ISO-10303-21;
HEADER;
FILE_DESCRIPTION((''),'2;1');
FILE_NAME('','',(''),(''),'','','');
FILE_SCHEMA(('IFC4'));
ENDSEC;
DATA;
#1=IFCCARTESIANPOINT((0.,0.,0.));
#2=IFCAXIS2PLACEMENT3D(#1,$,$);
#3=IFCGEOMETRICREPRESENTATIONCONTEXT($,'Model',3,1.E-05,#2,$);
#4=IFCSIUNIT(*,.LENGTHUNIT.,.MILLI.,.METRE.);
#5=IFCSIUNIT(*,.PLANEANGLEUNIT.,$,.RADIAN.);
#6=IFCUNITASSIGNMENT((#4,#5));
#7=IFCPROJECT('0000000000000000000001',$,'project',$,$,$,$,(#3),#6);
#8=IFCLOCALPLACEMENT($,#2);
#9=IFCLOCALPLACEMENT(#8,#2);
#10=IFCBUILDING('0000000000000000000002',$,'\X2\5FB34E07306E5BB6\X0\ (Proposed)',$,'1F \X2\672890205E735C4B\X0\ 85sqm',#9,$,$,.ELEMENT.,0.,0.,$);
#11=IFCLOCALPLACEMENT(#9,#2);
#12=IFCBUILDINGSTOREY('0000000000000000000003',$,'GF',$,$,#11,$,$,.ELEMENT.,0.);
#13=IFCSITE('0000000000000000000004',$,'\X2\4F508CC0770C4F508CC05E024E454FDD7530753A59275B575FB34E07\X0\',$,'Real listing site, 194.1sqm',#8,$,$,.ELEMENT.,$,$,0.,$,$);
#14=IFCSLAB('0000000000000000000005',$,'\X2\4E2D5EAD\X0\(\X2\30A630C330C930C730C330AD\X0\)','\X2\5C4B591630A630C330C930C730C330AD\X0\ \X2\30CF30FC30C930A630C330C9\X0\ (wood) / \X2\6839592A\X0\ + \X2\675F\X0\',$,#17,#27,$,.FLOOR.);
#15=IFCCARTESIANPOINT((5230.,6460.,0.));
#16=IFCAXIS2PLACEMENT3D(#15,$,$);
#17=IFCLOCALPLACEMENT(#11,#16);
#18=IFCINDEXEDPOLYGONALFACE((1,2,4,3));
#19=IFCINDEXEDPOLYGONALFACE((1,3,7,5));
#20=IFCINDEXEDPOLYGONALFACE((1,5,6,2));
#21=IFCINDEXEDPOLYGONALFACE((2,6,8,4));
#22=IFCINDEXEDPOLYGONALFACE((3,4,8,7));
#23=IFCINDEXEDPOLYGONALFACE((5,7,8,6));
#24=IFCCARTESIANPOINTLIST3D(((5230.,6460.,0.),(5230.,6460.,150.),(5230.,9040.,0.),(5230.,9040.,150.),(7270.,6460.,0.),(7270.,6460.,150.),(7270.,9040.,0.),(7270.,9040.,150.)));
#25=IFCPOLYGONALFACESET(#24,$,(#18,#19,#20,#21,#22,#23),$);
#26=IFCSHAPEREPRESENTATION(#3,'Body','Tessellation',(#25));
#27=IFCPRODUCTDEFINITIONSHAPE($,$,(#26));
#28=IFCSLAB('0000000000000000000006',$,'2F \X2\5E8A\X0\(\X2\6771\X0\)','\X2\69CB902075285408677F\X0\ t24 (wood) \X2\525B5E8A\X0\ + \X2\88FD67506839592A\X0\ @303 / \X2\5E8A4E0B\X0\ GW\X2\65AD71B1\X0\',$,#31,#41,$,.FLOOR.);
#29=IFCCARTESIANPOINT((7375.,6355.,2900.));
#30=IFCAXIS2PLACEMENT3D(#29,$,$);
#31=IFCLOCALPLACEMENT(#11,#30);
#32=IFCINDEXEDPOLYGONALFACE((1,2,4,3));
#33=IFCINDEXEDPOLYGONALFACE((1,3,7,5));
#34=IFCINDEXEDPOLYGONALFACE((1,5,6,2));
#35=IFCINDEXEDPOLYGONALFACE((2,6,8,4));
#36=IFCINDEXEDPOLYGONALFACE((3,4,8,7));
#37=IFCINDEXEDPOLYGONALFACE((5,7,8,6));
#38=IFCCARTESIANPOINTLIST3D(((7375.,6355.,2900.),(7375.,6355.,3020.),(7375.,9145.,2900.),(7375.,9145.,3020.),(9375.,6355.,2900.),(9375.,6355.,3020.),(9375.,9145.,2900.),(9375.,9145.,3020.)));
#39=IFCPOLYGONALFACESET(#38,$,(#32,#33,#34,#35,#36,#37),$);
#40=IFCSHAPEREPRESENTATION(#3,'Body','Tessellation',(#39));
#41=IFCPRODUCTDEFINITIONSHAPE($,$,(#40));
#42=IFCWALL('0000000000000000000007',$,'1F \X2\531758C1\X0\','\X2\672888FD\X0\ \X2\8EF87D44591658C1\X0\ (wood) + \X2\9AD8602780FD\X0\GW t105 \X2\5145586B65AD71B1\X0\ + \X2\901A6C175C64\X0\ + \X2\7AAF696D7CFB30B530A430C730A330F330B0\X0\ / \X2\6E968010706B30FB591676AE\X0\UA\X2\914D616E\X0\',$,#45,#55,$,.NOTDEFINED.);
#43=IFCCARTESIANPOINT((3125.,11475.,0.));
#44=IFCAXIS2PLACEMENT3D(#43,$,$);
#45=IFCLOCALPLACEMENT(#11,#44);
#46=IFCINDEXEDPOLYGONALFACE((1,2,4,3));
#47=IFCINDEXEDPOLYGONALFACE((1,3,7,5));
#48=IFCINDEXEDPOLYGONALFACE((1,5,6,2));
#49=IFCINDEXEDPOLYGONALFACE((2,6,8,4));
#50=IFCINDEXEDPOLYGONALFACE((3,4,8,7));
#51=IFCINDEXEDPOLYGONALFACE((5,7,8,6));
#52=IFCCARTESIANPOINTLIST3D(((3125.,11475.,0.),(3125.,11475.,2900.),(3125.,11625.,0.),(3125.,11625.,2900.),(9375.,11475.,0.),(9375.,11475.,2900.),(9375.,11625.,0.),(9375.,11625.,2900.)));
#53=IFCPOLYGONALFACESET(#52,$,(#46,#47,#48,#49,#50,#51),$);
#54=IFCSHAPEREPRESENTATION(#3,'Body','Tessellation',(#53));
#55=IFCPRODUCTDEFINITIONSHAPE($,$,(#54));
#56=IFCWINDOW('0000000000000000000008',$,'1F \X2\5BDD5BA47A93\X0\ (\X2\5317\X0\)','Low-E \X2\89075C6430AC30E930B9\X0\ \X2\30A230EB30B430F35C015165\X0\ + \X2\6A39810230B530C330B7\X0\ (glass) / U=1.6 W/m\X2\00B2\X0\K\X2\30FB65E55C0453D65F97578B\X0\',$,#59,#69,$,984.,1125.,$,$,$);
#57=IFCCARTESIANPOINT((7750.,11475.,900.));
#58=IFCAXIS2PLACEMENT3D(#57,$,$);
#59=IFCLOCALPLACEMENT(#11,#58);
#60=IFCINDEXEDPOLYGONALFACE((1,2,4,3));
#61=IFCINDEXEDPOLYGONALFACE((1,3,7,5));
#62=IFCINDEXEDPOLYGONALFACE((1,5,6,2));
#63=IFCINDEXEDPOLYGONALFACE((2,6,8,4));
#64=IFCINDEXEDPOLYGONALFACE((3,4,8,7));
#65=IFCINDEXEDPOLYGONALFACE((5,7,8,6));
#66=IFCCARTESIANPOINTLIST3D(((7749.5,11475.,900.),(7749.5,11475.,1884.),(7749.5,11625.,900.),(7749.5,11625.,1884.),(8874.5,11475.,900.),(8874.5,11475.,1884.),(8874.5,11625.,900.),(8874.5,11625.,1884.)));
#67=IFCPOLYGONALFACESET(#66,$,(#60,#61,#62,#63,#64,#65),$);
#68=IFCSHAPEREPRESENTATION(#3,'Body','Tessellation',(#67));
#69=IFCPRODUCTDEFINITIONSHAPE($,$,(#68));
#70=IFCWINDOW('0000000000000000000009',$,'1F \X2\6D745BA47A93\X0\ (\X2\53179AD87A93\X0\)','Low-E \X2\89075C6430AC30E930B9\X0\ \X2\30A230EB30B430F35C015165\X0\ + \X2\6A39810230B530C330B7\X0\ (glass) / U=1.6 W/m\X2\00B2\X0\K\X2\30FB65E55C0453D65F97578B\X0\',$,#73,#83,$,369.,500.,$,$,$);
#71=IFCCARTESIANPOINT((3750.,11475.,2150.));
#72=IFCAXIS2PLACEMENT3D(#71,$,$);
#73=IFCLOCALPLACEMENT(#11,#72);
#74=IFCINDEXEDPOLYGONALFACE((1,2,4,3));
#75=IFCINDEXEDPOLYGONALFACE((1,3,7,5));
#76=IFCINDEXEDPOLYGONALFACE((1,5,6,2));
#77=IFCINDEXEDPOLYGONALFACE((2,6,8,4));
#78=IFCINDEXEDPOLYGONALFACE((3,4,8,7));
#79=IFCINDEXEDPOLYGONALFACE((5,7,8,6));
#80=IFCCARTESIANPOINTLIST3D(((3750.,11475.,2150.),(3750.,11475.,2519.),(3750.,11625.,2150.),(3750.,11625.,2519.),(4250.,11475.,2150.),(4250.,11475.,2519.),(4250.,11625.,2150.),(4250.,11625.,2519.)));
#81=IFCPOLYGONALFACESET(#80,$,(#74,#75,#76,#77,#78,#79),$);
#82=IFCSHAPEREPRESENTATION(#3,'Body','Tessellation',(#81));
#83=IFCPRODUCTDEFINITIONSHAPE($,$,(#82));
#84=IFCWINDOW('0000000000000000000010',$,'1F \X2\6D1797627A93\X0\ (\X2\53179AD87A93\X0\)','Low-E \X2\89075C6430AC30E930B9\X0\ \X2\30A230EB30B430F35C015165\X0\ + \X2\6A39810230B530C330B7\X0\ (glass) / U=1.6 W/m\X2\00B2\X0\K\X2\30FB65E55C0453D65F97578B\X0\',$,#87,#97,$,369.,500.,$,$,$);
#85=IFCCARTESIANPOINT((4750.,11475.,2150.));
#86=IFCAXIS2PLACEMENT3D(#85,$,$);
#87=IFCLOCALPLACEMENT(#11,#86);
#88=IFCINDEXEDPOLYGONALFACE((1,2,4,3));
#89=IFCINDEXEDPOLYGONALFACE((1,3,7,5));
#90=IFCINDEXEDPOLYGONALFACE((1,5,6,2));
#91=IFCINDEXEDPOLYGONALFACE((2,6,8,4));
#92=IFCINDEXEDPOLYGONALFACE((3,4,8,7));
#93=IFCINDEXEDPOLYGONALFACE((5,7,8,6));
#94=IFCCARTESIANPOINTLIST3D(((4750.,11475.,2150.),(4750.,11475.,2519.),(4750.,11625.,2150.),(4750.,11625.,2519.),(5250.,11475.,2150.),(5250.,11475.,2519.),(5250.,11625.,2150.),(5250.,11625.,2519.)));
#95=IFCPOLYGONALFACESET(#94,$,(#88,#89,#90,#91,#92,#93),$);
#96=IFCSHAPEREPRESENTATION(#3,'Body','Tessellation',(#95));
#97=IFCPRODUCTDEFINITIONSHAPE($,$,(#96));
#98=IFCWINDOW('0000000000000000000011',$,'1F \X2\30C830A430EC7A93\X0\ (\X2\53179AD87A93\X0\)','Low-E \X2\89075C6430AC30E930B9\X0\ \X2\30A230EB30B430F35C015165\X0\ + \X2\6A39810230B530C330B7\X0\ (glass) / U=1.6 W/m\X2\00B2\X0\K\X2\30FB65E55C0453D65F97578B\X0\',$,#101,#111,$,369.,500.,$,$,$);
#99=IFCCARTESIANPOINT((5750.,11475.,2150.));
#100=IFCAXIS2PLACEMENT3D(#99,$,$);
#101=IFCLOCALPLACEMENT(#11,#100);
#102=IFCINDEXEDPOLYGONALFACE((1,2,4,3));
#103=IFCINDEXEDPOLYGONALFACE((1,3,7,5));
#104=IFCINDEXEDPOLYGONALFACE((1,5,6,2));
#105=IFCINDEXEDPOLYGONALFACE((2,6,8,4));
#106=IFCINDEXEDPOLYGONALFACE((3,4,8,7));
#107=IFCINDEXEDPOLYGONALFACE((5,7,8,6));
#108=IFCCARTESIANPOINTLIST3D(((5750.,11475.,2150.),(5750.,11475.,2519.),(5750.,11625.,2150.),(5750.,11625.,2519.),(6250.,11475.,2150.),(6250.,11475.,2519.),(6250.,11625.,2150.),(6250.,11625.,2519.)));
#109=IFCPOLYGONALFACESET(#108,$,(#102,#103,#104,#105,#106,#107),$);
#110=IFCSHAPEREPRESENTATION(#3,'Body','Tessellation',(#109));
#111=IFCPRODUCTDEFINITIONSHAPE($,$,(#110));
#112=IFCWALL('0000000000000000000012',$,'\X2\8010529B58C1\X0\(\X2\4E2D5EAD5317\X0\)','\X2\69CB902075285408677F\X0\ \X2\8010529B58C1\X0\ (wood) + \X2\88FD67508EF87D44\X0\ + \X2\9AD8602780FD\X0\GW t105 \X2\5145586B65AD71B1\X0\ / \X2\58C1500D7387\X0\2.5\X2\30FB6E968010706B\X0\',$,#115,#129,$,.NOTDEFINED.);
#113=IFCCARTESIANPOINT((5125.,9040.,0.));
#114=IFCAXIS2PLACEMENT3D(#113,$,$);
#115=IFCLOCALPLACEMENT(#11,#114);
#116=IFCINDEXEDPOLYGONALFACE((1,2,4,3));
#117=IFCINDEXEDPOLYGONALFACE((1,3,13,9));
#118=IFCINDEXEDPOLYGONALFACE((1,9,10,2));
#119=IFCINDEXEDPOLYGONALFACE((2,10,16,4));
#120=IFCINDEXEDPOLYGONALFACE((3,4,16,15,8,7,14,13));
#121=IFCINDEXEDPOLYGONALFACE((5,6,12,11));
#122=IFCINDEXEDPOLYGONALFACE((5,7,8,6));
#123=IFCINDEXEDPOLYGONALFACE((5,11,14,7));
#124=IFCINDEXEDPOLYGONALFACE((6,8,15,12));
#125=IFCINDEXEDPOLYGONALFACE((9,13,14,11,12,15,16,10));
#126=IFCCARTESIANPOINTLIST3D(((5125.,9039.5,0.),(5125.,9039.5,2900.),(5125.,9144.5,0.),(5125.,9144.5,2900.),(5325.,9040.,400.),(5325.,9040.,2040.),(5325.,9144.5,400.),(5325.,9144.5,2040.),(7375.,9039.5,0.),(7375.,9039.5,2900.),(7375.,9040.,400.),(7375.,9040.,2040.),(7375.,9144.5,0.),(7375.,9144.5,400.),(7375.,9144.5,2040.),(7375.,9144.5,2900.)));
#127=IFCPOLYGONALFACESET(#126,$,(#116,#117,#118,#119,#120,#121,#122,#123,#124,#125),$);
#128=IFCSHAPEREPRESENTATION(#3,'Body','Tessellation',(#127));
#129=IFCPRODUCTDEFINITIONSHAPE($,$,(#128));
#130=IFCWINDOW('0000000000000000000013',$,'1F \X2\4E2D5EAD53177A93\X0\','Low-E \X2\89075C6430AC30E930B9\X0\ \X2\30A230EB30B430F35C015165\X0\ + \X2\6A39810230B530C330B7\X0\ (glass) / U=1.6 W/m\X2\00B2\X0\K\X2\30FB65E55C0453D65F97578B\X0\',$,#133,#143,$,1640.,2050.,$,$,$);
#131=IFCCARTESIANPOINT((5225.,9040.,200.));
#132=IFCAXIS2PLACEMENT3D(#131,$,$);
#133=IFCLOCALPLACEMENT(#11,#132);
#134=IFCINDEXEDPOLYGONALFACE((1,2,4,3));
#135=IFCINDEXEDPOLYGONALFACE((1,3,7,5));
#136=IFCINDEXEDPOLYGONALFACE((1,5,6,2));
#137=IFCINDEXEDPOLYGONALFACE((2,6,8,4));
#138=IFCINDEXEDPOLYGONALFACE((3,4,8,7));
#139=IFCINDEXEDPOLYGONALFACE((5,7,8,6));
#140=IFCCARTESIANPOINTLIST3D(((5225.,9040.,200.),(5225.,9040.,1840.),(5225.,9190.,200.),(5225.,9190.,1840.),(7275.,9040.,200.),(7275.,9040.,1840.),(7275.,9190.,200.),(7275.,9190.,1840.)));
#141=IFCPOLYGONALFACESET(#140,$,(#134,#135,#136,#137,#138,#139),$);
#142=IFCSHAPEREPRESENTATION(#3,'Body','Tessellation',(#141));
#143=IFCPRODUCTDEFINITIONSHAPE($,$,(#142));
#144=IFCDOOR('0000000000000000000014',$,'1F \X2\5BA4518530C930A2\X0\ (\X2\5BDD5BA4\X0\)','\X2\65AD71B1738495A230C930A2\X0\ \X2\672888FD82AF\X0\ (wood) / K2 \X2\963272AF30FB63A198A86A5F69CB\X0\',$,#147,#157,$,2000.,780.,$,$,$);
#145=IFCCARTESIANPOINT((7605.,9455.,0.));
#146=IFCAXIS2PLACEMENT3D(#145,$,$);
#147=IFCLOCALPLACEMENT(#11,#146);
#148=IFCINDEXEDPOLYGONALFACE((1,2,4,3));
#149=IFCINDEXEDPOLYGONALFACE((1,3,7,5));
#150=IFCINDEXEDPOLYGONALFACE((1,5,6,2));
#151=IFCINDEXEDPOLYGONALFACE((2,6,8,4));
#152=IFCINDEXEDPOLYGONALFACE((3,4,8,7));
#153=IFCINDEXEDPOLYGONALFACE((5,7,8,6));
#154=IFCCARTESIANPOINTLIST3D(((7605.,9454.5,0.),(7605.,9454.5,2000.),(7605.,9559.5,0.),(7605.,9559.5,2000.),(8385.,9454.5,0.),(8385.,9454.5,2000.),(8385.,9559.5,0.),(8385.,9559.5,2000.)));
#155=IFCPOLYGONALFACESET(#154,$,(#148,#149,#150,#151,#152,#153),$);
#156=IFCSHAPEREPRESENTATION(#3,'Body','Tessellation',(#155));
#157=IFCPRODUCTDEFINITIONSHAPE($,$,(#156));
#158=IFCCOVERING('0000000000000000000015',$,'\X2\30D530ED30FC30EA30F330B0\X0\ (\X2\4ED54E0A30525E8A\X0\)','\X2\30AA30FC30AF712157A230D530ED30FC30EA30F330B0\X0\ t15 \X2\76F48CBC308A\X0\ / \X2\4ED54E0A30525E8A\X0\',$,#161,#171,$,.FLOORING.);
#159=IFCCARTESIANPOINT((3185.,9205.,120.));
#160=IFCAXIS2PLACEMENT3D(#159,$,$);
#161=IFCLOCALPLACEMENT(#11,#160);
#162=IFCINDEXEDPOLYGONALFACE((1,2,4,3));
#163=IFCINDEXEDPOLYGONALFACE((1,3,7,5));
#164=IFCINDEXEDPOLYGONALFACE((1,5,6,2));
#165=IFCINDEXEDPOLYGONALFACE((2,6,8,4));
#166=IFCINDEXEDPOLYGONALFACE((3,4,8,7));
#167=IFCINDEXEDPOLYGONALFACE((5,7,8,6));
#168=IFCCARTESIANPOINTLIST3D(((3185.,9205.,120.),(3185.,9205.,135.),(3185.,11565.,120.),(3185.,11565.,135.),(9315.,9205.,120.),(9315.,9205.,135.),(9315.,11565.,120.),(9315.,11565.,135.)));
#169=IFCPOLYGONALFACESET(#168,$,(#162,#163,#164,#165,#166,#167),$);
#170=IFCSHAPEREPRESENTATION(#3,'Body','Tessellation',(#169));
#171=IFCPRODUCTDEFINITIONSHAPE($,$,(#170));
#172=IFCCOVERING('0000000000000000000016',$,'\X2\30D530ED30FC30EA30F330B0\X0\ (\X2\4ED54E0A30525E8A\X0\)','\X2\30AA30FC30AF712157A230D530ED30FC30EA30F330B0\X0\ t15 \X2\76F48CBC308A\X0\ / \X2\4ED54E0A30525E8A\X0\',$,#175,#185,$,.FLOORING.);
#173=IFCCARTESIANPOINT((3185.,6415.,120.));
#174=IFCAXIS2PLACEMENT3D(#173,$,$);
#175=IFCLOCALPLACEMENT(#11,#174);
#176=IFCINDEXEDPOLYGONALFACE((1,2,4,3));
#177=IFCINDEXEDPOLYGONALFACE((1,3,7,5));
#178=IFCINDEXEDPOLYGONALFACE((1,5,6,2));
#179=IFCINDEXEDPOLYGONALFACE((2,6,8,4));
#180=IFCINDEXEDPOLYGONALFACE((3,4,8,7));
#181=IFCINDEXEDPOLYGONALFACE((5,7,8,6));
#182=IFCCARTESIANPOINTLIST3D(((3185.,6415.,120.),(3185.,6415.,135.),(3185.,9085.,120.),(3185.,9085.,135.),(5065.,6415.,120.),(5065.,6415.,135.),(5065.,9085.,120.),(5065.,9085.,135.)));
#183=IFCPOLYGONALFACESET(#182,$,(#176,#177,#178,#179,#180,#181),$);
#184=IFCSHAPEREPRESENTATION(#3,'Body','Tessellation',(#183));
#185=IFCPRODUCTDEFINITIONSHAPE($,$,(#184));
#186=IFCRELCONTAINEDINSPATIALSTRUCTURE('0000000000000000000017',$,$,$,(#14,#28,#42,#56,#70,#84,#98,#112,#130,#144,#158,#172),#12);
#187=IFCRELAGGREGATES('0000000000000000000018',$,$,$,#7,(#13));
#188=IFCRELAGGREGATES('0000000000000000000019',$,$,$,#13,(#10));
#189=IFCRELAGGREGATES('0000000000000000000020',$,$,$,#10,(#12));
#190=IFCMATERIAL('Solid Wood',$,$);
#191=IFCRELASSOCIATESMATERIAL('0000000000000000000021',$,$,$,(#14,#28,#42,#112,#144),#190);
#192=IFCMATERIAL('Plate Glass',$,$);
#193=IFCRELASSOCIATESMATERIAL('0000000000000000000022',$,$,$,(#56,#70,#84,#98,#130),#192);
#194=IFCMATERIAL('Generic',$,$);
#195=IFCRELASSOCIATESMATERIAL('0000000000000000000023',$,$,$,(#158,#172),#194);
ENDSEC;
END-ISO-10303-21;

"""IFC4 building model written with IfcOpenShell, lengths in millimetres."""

from ifc_helpers import new_model, si_unit, frame, frame_2d, origin, place, context, project, spatial, rectangle, extrude, material, element, fill, save


model = new_model("IFC4")

# Units and contexts
model_context = context("Model", 3, precision=1e-05, world=origin())
ifc_project = project(units=[si_unit("LENGTHUNIT", "METRE", prefix="MILLI"), si_unit("PLANEANGLEUNIT", "RADIAN")], contexts=[model_context])

# Site, building, storey
site_placement = place(None, origin())
site = spatial("IfcSite", under=ifc_project, at=site_placement, Name="佐賀県佐賀市久保田町大字徳万", ObjectType="Real listing site, 194.1sqm", CompositionType="ELEMENT", RefElevation=0.0)
building_placement = place(site_placement, origin())
building = spatial("IfcBuilding", under=site, at=building_placement, Name="徳万の家 (Proposed)", ObjectType="1F 木造平屋 85sqm", CompositionType="ELEMENT", ElevationOfRefHeight=0.0, ElevationOfTerrain=0.0)
storey_placement = place(building_placement, origin())
storey = spatial("IfcBuildingStorey", under=building, at=storey_placement, Name="GF", CompositionType="ELEMENT", Elevation=0.0)

# Slabs
ifc_material_1 = material(Name="Solid Wood")
slab_1_placement = place(storey_placement, frame((5230.0, 6460.0, 0.0)))
element("IfcSlab", 1, at=slab_1_placement, inside=storey, material=ifc_material_1, Name="中庭(ウッドデッキ)", Description="屋外ウッドデッキ ハードウッド (wood) / 根太 + 束", PredefinedType="FLOOR", context=model_context, shape_type="SweptSolid", body=[
    extrude(rectangle(XDim=2040.0, YDim=2580.0, at=frame_2d((1020.0, 1290.0))), frame((5230.0, 6460.0, 0.0)), (0.0, 0.0, 1.0), 150.0),
])
slab_2_placement = place(storey_placement, frame((7375.0, 6355.0, 2900.0)))
element("IfcSlab", 2, at=slab_2_placement, inside=storey, material=ifc_material_1, Name="2F 床(東)", Description="構造用合板 t24 (wood) 剛床 + 製材根太 @303 / 床下 GW断熱", PredefinedType="FLOOR", context=model_context, shape_type="SweptSolid", body=[
    extrude(rectangle(XDim=2000.0, YDim=2790.0, at=frame_2d((1000.0, 1395.0))), frame((7375.0, 6355.0, 2900.0)), (0.0, 0.0, 1.0), 120.0),
])

# Wall, openings, windows
wall_1_placement = place(storey_placement, frame((3125.0, 11475.0, 0.0)))
wall_1 = element("IfcWall", 3, at=wall_1_placement, inside=storey, material=ifc_material_1, Name="1F 北壁", Description="木製 軸組外壁 (wood) + 高性能GW t105 充填断熱 + 通気層 + 窯業系サイディング / 準耐火・外皮UA配慮", PredefinedType="NOTDEFINED", context=model_context, shape_type="SweptSolid", body=[
    extrude(rectangle(XDim=6250.0, YDim=150.0, at=frame_2d((3125.0, 75.0))), frame((3125.0, 11475.0, 0.0)), (0.0, 0.0, 1.0), 2900.0),
])
opening_1_placement = place(storey_placement, frame((7750.0, 11475.0, 900.0)))
opening_1 = element("IfcOpeningElement", 4, at=opening_1_placement, cuts=wall_1, PredefinedType="NOTDEFINED", context=model_context, shape_type="SweptSolid", body=[
    extrude(rectangle(XDim=1125.0, YDim=150.0, at=frame_2d((562.0, 75.0))), frame((7750.0, 11475.0, 900.0)), (0.0, 0.0, 1.0), 984.0),
])
opening_2_placement = place(storey_placement, frame((3750.0, 11475.0, 2150.0)))
opening_2 = element("IfcOpeningElement", 5, at=opening_2_placement, cuts=wall_1, PredefinedType="NOTDEFINED", context=model_context, shape_type="SweptSolid", body=[
    extrude(rectangle(XDim=500.0, YDim=150.0, at=frame_2d((250.0, 75.0))), frame((3750.0, 11475.0, 2150.0)), (0.0, 0.0, 1.0), 369.0),
])
opening_3_placement = place(storey_placement, frame((4750.0, 11475.0, 2150.0)))
opening_3 = element("IfcOpeningElement", 6, at=opening_3_placement, cuts=wall_1, PredefinedType="NOTDEFINED", context=model_context, shape_type="SweptSolid", body=[
    extrude(rectangle(XDim=500.0, YDim=150.0, at=frame_2d((250.0, 75.0))), frame((4750.0, 11475.0, 2150.0)), (0.0, 0.0, 1.0), 369.0),
])
opening_4_placement = place(storey_placement, frame((5750.0, 11475.0, 2150.0)))
opening_4 = element("IfcOpeningElement", 7, at=opening_4_placement, cuts=wall_1, PredefinedType="NOTDEFINED", context=model_context, shape_type="SweptSolid", body=[
    extrude(rectangle(XDim=500.0, YDim=150.0, at=frame_2d((250.0, 75.0))), frame((5750.0, 11475.0, 2150.0)), (0.0, 0.0, 1.0), 369.0),
])
ifc_material_2 = material(Name="Plate Glass")
window_1_placement = place(storey_placement, frame((7750.0, 11475.0, 900.0)))
window_1 = element("IfcWindow", 8, at=window_1_placement, inside=storey, material=ifc_material_2, Name="1F 寝室窓 (北)", Description="Low-E 複層ガラス アルゴン封入 + 樹脂サッシ (glass) / U=1.6 W/m²K・日射取得型", OverallHeight=984.0, OverallWidth=1125.0, context=model_context, shape_type="SweptSolid", body=[
    extrude(rectangle(XDim=1125.0, YDim=150.0, at=frame_2d((562.0, 75.0))), frame((7750.0, 11475.0, 900.0)), (0.0, 0.0, 1.0), 984.0),
])
fill(opening_1, window_1)
window_2_placement = place(storey_placement, frame((3750.0, 11475.0, 2150.0)))
window_2 = element("IfcWindow", 9, at=window_2_placement, inside=storey, material=ifc_material_2, Name="1F 浴室窓 (北高窓)", Description="Low-E 複層ガラス アルゴン封入 + 樹脂サッシ (glass) / U=1.6 W/m²K・日射取得型", OverallHeight=369.0, OverallWidth=500.0, context=model_context, shape_type="SweptSolid", body=[
    extrude(rectangle(XDim=500.0, YDim=150.0, at=frame_2d((250.0, 75.0))), frame((3750.0, 11475.0, 2150.0)), (0.0, 0.0, 1.0), 369.0),
])
fill(opening_2, window_2)
window_3_placement = place(storey_placement, frame((4750.0, 11475.0, 2150.0)))
window_3 = element("IfcWindow", 10, at=window_3_placement, inside=storey, material=ifc_material_2, Name="1F 洗面窓 (北高窓)", Description="Low-E 複層ガラス アルゴン封入 + 樹脂サッシ (glass) / U=1.6 W/m²K・日射取得型", OverallHeight=369.0, OverallWidth=500.0, context=model_context, shape_type="SweptSolid", body=[
    extrude(rectangle(XDim=500.0, YDim=150.0, at=frame_2d((250.0, 75.0))), frame((4750.0, 11475.0, 2150.0)), (0.0, 0.0, 1.0), 369.0),
])
fill(opening_3, window_3)
window_4_placement = place(storey_placement, frame((5750.0, 11475.0, 2150.0)))
window_4 = element("IfcWindow", 11, at=window_4_placement, inside=storey, material=ifc_material_2, Name="1F トイレ窓 (北高窓)", Description="Low-E 複層ガラス アルゴン封入 + 樹脂サッシ (glass) / U=1.6 W/m²K・日射取得型", OverallHeight=369.0, OverallWidth=500.0, context=model_context, shape_type="SweptSolid", body=[
    extrude(rectangle(XDim=500.0, YDim=150.0, at=frame_2d((250.0, 75.0))), frame((5750.0, 11475.0, 2150.0)), (0.0, 0.0, 1.0), 369.0),
])
fill(opening_4, window_4)

# Wall, opening, window
wall_2_placement = place(storey_placement, frame((5125.0, 9040.0, 0.0)))
wall_2 = element("IfcWall", 12, at=wall_2_placement, inside=storey, material=ifc_material_1, Name="耐力壁(中庭北)", Description="構造用合板 耐力壁 (wood) + 製材軸組 + 高性能GW t105 充填断熱 / 壁倍率2.5・準耐火", PredefinedType="NOTDEFINED", context=model_context, shape_type="SweptSolid", body=[
    extrude(rectangle(XDim=2250.0, YDim=105.0, at=frame_2d((1125.0, 52.0))), frame((5125.0, 9040.0, 0.0)), (0.0, 0.0, 1.0), 2900.0),
])
opening_5_placement = place(storey_placement, frame((5225.0, 9040.0, 200.0)))
opening_5 = element("IfcOpeningElement", 13, at=opening_5_placement, cuts=wall_2, PredefinedType="NOTDEFINED", context=model_context, shape_type="SweptSolid", body=[
    extrude(rectangle(XDim=2050.0, YDim=150.0, at=frame_2d((1025.0, 75.0))), frame((5225.0, 9040.0, 200.0)), (0.0, 0.0, 1.0), 1640.0),
])
window_5_placement = place(storey_placement, frame((5225.0, 9040.0, 200.0)))
window_5 = element("IfcWindow", 14, at=window_5_placement, inside=storey, material=ifc_material_2, Name="1F 中庭北窓", Description="Low-E 複層ガラス アルゴン封入 + 樹脂サッシ (glass) / U=1.6 W/m²K・日射取得型", OverallHeight=1640.0, OverallWidth=2050.0, context=model_context, shape_type="SweptSolid", body=[
    extrude(rectangle(XDim=2050.0, YDim=150.0, at=frame_2d((1025.0, 75.0))), frame((5225.0, 9040.0, 200.0)), (0.0, 0.0, 1.0), 1640.0),
])
fill(opening_5, window_5)

# Door
door_1_placement = place(storey_placement, frame((7605.0, 9455.0, 0.0)))
element("IfcDoor", 15, at=door_1_placement, inside=storey, material=ifc_material_1, Name="1F 室内ドア (寝室)", Description="断熱玄関ドア 木製芯 (wood) / K2 防犯・採風機構", OverallHeight=2000.0, OverallWidth=780.0, context=model_context, shape_type="SweptSolid", body=[
    extrude(rectangle(XDim=780.0, YDim=105.0, at=frame_2d((390.0, 52.0))), frame((7605.0, 9455.0, 0.0)), (0.0, 0.0, 1.0), 2000.0),
])

# Coverings
ifc_material_3 = material(Name="Generic")
covering_1_placement = place(storey_placement, frame((3185.0, 9205.0, 120.0)))
element("IfcCovering", 16, at=covering_1_placement, inside=storey, material=ifc_material_3, Name="フローリング (仕上げ床)", Description="オーク無垢フローリング t15 直貼り / 仕上げ床", PredefinedType="FLOORING", context=model_context, shape_type="SweptSolid", body=[
    extrude(rectangle(XDim=6130.0, YDim=2360.0, at=frame_2d((3065.0, 1180.0))), frame((3185.0, 9205.0, 120.0)), (0.0, 0.0, 1.0), 15.0),
])
covering_2_placement = place(storey_placement, frame((3185.0, 6415.0, 120.0)))
element("IfcCovering", 17, at=covering_2_placement, inside=storey, material=ifc_material_3, Name="フローリング (仕上げ床)", Description="オーク無垢フローリング t15 直貼り / 仕上げ床", PredefinedType="FLOORING", context=model_context, shape_type="SweptSolid", body=[
    extrude(rectangle(XDim=1880.0, YDim=2670.0, at=frame_2d((940.0, 1335.0))), frame((3185.0, 6415.0, 120.0)), (0.0, 0.0, 1.0), 15.0),
])

save(model, "model.ifc")
